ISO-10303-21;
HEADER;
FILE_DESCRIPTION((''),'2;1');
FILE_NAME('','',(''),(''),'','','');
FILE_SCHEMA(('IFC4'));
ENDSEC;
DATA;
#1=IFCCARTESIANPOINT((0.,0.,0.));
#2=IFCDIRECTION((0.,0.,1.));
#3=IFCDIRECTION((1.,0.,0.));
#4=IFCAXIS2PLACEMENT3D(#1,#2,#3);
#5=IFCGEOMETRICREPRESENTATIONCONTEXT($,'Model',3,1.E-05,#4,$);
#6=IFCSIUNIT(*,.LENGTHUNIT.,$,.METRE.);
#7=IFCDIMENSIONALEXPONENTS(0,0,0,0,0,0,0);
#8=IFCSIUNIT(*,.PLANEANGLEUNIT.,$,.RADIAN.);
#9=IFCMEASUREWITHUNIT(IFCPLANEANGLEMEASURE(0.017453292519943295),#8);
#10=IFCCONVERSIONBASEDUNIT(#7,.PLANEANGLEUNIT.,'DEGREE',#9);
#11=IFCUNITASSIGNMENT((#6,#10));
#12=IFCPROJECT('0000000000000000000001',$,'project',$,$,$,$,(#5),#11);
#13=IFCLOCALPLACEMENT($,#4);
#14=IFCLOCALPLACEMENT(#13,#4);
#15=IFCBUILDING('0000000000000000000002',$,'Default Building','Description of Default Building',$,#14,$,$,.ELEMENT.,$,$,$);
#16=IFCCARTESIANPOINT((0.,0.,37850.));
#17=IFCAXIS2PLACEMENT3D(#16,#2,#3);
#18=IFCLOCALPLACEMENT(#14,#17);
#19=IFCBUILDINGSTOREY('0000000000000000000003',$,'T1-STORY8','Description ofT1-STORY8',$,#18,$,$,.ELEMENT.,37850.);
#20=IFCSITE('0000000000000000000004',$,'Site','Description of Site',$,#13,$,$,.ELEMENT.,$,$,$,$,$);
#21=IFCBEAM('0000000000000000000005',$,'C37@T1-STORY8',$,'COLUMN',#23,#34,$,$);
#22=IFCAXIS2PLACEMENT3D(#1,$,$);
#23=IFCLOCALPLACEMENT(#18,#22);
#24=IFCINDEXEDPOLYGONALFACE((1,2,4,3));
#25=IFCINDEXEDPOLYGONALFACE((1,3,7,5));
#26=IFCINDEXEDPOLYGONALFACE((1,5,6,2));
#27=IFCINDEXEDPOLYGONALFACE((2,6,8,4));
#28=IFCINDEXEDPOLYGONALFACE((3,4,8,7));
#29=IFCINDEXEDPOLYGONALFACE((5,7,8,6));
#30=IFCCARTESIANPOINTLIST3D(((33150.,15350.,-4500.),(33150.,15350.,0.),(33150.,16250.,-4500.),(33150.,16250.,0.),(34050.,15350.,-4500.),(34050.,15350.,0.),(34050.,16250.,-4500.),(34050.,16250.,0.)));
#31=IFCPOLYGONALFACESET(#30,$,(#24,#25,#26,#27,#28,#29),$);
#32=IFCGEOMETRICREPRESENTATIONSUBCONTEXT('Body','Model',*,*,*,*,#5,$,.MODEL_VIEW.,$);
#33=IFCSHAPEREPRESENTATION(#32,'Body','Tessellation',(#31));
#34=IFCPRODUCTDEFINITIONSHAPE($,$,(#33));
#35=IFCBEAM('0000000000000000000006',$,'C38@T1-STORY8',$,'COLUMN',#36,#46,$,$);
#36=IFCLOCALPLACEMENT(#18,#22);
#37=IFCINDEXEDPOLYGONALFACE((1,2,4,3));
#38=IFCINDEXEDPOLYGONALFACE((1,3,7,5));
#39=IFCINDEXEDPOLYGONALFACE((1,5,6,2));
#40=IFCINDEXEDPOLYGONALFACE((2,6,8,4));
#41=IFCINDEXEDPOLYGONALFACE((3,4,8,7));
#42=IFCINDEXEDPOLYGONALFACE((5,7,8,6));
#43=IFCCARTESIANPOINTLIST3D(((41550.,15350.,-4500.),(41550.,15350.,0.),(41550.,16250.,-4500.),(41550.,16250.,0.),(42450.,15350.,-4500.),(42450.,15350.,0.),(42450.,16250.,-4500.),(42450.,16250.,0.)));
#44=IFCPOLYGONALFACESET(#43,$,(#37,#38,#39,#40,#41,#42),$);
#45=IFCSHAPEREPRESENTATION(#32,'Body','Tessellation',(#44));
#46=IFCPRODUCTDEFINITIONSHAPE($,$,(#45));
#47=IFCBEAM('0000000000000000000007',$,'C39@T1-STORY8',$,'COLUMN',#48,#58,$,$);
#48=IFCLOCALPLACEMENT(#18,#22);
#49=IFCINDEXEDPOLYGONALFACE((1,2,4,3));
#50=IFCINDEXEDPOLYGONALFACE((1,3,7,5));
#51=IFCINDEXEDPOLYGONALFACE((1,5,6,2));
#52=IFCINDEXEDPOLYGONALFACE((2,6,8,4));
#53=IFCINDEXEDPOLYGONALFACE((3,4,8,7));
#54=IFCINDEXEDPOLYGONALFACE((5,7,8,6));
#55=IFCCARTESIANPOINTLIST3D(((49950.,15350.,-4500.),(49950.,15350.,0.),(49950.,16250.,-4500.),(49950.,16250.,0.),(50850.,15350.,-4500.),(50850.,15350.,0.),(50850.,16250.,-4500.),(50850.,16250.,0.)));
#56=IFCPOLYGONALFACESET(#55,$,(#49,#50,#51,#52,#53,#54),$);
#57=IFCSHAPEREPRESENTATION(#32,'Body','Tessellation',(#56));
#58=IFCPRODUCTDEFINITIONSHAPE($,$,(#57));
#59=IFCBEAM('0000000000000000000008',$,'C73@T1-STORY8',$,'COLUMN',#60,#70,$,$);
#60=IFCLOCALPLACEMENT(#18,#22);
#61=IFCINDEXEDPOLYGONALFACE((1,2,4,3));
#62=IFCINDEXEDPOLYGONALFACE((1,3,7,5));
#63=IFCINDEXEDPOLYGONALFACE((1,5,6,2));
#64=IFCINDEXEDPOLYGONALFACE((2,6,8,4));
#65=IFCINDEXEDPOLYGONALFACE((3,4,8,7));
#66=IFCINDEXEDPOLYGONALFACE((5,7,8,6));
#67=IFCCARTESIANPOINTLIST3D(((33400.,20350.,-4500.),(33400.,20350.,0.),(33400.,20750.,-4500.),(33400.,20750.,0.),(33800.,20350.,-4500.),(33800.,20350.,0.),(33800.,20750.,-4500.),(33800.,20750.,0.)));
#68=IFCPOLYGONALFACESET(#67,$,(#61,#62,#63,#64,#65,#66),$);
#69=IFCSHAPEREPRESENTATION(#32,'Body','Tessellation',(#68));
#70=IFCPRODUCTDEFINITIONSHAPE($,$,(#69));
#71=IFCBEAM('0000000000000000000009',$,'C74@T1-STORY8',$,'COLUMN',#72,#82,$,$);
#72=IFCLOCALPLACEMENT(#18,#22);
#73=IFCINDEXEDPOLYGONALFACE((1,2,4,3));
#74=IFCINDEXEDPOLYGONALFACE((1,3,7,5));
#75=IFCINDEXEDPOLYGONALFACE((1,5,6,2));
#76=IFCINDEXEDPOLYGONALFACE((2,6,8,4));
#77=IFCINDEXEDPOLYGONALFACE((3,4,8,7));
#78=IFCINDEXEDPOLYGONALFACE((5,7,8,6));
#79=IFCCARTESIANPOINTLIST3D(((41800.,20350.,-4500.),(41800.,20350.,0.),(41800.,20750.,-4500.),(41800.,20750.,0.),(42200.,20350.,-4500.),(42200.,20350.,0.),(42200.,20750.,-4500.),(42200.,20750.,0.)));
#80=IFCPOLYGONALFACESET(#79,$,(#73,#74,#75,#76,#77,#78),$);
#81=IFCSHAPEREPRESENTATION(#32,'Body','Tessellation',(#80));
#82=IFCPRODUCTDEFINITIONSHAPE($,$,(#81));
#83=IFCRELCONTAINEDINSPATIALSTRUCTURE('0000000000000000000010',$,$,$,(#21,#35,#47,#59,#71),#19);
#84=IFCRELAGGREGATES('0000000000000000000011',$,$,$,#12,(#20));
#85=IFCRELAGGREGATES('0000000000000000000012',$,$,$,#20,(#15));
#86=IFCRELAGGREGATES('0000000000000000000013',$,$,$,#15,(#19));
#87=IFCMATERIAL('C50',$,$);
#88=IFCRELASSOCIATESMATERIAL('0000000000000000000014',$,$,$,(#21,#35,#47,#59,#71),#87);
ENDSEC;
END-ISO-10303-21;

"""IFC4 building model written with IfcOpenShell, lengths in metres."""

from ifc_helpers import new_model, entity, si_unit, converted_unit, frame, origin_with_axes, place, context, subcontext, project, spatial, rectangle, extrude, material, element, save


model = new_model("IFC4")

# Units and contexts
model_context = context("Model", 3, precision=1e-05, world=origin_with_axes())
body_context = subcontext(model_context, "Body", "Model", "MODEL_VIEW")
ifc_project = project(units=[si_unit("LENGTHUNIT", "METRE"), converted_unit("PLANEANGLEUNIT", "DEGREE", entity("IfcPlaneAngleMeasure", 0.017453292519943295), si_unit("PLANEANGLEUNIT", "RADIAN"), dimensions=[0, 0, 0, 0, 0, 0, 0])], contexts=[model_context])

# Site, building, storey
site_placement = place(None, origin_with_axes())
site = spatial("IfcSite", under=ifc_project, at=site_placement, Name="Site", Description="Description of Site", CompositionType="ELEMENT")
building_placement = place(site_placement, origin_with_axes())
building = spatial("IfcBuilding", under=site, at=building_placement, Name="Default Building", Description="Description of Default Building", CompositionType="ELEMENT")
storey_placement = place(building_placement, frame((0.0, 0.0, 37850.0), z_axis=(0.0, 0.0, 1.0), x_axis=(1.0, 0.0, 0.0)))
storey = spatial("IfcBuildingStorey", under=building, at=storey_placement, Name="T1-STORY8", Description="Description ofT1-STORY8", CompositionType="ELEMENT", Elevation=37850.0)

# Beams
ifc_material_1 = material(Name="C50")
for number, where, z_axis, x_axis, name in (
    (1, (33600.0, 15800.0, -4500.0), (0.0, 0.0, 1.0), (-1.0, 0.0, 0.0), "C37@T1-STORY8"),
    (2, (42000.0, 15800.0, -4500.0), (0.0, 0.0, 1.0), (-1.0, 0.0, 0.0), "C38@T1-STORY8"),
    (3, (50400.0, 15800.0, -4500.0), (0.0, 0.0, 1.0), (-1.0, 0.0, 0.0), "C39@T1-STORY8"),
):
    element("IfcBeam", number, at=place(storey_placement, frame(where, z_axis=z_axis, x_axis=x_axis)), inside=storey, material=ifc_material_1, Name=name, ObjectType="COLUMN", context=body_context, shape_type="SweptSolid", body=[
        extrude(rectangle(XDim=900.0, YDim=900.0), origin_with_axes(), (0.0, 0.0, 1.0), 4500.0),
    ])
for number, where, z_axis, x_axis, name in (
    (4, (33600.0, 20550.0, -4500.0), (0.0, 0.0, 1.0), (-1.0, 0.0, 0.0), "C73@T1-STORY8"),
    (5, (42000.0, 20550.0, -4500.0), (0.0, 0.0, 1.0), (-1.0, 0.0, 0.0), "C74@T1-STORY8"),
):
    element("IfcBeam", number, at=place(storey_placement, frame(where, z_axis=z_axis, x_axis=x_axis)), inside=storey, material=ifc_material_1, Name=name, ObjectType="COLUMN", context=body_context, shape_type="SweptSolid", body=[
        extrude(rectangle(XDim=400.0, YDim=400.0), origin_with_axes(), (0.0, 0.0, 1.0), 4500.0),
    ])

save(model, "model.ifc")
